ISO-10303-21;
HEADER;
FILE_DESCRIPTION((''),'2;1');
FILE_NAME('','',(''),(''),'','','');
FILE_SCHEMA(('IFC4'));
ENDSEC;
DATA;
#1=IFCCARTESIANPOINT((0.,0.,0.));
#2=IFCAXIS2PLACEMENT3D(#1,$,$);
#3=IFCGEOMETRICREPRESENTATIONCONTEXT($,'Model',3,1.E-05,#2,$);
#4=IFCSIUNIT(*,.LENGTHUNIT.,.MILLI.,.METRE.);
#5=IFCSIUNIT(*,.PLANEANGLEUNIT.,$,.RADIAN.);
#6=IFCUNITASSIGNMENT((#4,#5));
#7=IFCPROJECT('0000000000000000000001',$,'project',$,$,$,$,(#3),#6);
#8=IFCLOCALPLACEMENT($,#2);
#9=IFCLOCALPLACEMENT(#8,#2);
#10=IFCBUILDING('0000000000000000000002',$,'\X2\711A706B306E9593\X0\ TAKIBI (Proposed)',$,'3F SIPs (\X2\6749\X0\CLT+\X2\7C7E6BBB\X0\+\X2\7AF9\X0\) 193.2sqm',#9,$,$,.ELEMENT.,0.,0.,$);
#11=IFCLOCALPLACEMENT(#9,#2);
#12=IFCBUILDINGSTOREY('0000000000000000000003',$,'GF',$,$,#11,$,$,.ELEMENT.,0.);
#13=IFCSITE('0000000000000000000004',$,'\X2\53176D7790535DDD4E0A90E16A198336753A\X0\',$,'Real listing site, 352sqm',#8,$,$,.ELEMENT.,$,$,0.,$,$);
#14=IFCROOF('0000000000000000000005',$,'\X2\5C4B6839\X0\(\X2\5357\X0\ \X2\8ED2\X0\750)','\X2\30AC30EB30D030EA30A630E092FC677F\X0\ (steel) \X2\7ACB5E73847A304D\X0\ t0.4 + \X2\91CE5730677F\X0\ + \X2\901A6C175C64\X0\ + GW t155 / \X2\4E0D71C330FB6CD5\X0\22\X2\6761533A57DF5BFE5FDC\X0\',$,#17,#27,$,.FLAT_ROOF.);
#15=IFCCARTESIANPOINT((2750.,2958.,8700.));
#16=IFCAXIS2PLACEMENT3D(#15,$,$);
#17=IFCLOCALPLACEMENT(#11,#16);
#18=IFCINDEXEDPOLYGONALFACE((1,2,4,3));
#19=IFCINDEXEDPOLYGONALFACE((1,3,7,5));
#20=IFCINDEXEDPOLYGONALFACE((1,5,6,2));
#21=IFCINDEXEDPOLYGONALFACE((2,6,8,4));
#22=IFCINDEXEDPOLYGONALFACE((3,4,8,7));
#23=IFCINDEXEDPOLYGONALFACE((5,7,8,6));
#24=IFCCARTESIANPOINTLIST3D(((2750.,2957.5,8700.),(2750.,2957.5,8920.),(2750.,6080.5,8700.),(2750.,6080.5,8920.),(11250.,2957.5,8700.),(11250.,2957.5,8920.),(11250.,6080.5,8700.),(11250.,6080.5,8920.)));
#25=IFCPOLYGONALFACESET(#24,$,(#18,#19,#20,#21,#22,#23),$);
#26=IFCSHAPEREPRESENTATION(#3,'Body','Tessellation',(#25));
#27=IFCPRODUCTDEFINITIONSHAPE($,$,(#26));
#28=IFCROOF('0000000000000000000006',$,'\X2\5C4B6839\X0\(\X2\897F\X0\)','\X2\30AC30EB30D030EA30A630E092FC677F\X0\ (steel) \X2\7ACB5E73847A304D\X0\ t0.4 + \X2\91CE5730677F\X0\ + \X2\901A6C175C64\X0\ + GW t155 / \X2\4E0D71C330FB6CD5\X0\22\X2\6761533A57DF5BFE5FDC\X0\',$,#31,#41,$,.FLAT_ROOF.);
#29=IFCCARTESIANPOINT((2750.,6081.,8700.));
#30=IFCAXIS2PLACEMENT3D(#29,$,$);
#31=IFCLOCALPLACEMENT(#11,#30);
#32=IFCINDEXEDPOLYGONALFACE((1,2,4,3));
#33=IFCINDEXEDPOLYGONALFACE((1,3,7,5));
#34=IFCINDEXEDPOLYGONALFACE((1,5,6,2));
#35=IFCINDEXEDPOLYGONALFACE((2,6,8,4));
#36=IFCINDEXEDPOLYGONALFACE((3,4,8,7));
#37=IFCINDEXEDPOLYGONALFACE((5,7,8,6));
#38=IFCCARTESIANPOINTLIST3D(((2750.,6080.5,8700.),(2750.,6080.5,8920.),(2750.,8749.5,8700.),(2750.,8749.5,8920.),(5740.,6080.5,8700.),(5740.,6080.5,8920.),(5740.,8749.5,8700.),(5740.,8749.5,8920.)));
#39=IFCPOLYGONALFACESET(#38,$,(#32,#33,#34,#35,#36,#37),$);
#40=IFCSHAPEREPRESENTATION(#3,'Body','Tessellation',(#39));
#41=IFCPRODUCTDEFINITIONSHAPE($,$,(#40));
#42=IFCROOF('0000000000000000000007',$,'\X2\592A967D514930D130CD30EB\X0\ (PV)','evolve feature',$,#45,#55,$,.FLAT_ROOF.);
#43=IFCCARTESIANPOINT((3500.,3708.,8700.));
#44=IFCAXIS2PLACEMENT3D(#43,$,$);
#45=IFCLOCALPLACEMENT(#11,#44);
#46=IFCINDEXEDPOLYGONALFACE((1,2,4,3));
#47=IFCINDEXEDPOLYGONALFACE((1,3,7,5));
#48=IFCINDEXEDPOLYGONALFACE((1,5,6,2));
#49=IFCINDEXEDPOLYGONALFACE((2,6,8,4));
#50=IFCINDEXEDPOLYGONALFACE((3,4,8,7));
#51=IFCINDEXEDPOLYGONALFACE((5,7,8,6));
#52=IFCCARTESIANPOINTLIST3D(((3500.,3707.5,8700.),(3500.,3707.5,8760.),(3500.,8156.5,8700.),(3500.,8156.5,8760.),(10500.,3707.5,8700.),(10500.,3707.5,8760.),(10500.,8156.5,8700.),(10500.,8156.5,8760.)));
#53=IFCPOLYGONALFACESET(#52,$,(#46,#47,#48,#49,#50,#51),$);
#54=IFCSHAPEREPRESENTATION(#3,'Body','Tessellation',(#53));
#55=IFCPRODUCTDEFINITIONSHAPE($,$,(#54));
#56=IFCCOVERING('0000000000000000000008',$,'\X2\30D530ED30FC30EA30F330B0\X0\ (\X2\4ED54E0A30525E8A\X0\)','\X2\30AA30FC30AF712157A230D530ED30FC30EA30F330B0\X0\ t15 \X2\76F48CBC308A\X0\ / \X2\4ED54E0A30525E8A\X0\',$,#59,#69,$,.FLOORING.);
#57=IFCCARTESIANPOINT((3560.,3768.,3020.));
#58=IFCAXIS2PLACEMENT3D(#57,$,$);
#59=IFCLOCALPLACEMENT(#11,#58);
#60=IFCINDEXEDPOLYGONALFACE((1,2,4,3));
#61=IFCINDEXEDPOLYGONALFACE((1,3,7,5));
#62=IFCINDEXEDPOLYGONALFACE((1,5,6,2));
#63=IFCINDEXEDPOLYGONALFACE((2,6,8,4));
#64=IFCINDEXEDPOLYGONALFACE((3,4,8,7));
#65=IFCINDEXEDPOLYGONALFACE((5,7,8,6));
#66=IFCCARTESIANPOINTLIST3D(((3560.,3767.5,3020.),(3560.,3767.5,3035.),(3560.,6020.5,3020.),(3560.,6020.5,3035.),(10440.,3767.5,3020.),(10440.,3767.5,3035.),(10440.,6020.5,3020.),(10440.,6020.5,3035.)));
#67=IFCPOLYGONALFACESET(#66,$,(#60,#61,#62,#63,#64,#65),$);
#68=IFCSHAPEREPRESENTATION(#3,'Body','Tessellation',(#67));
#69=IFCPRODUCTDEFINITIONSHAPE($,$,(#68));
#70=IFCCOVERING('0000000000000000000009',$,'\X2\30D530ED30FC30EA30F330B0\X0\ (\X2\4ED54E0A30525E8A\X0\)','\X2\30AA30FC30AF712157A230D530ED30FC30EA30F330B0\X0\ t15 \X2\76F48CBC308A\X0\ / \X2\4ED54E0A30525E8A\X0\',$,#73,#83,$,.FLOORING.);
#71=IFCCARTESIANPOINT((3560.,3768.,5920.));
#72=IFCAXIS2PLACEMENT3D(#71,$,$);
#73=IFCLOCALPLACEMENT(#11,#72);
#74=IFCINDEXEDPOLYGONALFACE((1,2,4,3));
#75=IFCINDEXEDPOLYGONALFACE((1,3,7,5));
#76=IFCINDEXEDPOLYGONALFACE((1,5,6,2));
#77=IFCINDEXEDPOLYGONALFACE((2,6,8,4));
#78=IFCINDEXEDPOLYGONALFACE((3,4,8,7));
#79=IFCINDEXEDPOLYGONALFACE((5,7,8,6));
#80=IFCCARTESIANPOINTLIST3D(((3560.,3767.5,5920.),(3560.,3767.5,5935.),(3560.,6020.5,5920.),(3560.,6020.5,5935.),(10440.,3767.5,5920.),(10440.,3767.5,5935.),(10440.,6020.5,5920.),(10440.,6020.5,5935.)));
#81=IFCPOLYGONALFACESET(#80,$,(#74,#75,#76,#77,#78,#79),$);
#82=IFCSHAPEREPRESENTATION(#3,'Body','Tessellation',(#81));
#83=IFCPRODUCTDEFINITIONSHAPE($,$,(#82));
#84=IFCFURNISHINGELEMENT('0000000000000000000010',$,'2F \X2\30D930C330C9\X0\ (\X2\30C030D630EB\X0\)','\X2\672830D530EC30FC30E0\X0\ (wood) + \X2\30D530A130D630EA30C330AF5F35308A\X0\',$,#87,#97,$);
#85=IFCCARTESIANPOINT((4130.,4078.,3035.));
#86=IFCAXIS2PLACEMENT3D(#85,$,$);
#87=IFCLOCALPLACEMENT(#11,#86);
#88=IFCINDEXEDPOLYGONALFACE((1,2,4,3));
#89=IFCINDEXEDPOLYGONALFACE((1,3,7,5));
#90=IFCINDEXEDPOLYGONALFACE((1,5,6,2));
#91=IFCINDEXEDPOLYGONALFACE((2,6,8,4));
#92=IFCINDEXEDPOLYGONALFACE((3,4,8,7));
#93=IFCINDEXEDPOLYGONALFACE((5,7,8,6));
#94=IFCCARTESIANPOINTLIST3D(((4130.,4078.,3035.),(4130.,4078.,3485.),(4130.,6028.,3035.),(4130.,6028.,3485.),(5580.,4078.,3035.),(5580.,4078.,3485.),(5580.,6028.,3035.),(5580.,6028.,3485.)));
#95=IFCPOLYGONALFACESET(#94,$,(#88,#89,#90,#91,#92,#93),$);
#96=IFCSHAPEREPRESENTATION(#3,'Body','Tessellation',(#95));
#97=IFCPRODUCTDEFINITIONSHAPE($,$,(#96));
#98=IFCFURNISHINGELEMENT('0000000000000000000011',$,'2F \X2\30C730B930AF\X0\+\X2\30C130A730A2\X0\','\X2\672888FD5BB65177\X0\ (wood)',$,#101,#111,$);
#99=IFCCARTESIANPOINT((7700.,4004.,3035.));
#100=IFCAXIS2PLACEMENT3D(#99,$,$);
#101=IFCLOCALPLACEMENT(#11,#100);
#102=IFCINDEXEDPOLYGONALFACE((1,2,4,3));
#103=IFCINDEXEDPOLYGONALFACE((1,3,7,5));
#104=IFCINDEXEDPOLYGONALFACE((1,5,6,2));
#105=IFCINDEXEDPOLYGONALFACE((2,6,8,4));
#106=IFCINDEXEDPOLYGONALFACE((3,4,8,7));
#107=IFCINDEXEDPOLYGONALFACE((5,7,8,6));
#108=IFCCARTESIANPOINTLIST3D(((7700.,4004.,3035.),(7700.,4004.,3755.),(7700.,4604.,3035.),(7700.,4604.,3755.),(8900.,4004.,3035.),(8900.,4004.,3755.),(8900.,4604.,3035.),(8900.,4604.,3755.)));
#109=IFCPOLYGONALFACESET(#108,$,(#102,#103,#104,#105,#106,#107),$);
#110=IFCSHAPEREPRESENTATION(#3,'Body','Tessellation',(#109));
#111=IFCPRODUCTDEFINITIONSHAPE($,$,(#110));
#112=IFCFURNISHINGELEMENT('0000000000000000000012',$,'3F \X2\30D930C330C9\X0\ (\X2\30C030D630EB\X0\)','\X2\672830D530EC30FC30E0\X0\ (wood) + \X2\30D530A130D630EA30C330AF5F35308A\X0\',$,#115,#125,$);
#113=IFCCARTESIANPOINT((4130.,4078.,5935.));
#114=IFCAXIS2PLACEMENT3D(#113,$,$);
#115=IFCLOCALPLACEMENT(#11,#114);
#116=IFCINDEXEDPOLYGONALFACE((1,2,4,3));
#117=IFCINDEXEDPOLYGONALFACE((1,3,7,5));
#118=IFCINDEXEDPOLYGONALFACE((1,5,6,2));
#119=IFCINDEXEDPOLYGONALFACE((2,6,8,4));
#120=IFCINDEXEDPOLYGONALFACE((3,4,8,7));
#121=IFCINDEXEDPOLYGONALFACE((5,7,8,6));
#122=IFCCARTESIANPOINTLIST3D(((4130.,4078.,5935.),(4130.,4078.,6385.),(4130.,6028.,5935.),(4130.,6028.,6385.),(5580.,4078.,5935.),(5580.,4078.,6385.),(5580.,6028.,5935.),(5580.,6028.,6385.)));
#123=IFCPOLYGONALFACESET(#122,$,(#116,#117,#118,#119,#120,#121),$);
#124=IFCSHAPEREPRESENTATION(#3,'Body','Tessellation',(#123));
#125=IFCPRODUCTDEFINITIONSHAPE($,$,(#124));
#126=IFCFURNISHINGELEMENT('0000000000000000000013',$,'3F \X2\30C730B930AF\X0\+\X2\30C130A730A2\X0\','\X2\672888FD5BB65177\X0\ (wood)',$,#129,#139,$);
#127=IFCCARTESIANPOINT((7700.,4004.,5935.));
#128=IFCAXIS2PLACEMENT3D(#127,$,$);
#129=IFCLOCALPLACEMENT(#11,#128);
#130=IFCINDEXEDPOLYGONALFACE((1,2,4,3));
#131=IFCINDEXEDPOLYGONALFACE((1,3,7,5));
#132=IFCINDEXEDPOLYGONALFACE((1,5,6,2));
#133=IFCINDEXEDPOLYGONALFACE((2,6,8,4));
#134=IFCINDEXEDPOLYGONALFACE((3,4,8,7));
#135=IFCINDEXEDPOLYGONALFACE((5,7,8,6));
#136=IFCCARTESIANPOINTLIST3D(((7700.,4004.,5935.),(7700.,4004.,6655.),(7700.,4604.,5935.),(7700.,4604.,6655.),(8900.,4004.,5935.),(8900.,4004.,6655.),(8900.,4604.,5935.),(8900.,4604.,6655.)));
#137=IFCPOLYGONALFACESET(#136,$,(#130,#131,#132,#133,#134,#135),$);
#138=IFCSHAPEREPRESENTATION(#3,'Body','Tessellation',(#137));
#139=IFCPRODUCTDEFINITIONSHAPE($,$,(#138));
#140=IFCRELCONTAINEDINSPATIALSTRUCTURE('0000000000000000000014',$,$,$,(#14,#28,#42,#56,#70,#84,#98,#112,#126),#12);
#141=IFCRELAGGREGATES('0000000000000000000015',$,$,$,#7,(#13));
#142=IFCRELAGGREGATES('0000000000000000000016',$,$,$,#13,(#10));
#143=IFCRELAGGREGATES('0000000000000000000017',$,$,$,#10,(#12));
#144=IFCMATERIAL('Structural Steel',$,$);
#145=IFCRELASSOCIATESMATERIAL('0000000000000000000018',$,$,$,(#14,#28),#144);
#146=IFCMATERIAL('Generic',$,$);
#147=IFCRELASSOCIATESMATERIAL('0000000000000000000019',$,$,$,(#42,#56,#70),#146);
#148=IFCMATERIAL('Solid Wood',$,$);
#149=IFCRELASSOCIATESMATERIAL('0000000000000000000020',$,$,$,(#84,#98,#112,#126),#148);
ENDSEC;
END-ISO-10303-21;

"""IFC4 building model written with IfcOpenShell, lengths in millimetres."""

from ifc_helpers import new_model, si_unit, frame, frame_2d, origin, place, context, project, spatial, rectangle, extrude, material, element, save


model = new_model("IFC4")

# Units and contexts
model_context = context("Model", 3, precision=1e-05, world=origin())
ifc_project = project(units=[si_unit("LENGTHUNIT", "METRE", prefix="MILLI"), si_unit("PLANEANGLEUNIT", "RADIAN")], contexts=[model_context])

# Site, building, storey
site_placement = place(None, origin())
site = spatial("IfcSite", under=ifc_project, at=site_placement, Name="北海道川上郡標茶町", ObjectType="Real listing site, 352sqm", CompositionType="ELEMENT", RefElevation=0.0)
building_placement = place(site_placement, origin())
building = spatial("IfcBuilding", under=site, at=building_placement, Name="焚火の間 TAKIBI (Proposed)", ObjectType="3F SIPs (杉CLT+籾殻+竹) 193.2sqm", CompositionType="ELEMENT", ElevationOfRefHeight=0.0, ElevationOfTerrain=0.0)
storey_placement = place(building_placement, origin())
storey = spatial("IfcBuildingStorey", under=building, at=storey_placement, Name="GF", CompositionType="ELEMENT", Elevation=0.0)

# Shared definitions
ifc_material_1 = material(Name="Solid Wood")

# Roofs
ifc_material_2 = material(Name="Structural Steel")
roof_1_placement = place(storey_placement, frame((2750.0, 2958.0, 8700.0)))
element("IfcRoof", 1, at=roof_1_placement, inside=storey, material=ifc_material_2, Name="屋根(南 軒750)", Description="ガルバリウム鋼板 (steel) 立平葺き t0.4 + 野地板 + 通気層 + GW t155 / 不燃・法22条区域対応", PredefinedType="FLAT_ROOF", context=model_context, shape_type="SweptSolid", body=[
    extrude(rectangle(XDim=8500.0, YDim=3123.0, at=frame_2d((4250.0, 1561.0))), frame((2750.0, 2958.0, 8700.0)), (0.0, 0.0, 1.0), 220.0),
])
roof_2_placement = place(storey_placement, frame((2750.0, 6081.0, 8700.0)))
element("IfcRoof", 2, at=roof_2_placement, inside=storey, material=ifc_material_2, Name="屋根(西)", Description="ガルバリウム鋼板 (steel) 立平葺き t0.4 + 野地板 + 通気層 + GW t155 / 不燃・法22条区域対応", PredefinedType="FLAT_ROOF", context=model_context, shape_type="SweptSolid", body=[
    extrude(rectangle(XDim=2990.0, YDim=2669.0, at=frame_2d((1495.0, 1334.0))), frame((2750.0, 6081.0, 8700.0)), (0.0, 0.0, 1.0), 220.0),
])
ifc_material_3 = material(Name="Generic")
roof_3_placement = place(storey_placement, frame((3500.0, 3708.0, 8700.0)))
element("IfcRoof", 3, at=roof_3_placement, inside=storey, material=ifc_material_3, Name="太陽光パネル (PV)", Description="evolve feature", PredefinedType="FLAT_ROOF", context=model_context, shape_type="SweptSolid", body=[
    extrude(rectangle(XDim=7000.0, YDim=4449.0, at=frame_2d((3500.0, 2224.0))), frame((3500.0, 3708.0, 8700.0)), (0.0, 0.0, 1.0), 60.0),
])

# Coverings
covering_1_placement = place(storey_placement, frame((3560.0, 3768.0, 3020.0)))
element("IfcCovering", 4, at=covering_1_placement, inside=storey, material=ifc_material_3, Name="フローリング (仕上げ床)", Description="オーク無垢フローリング t15 直貼り / 仕上げ床", PredefinedType="FLOORING", context=model_context, shape_type="SweptSolid", body=[
    extrude(rectangle(XDim=6880.0, YDim=2253.0, at=frame_2d((3440.0, 1126.0))), frame((3560.0, 3768.0, 3020.0)), (0.0, 0.0, 1.0), 15.0),
])
covering_2_placement = place(storey_placement, frame((3560.0, 3768.0, 5920.0)))
element("IfcCovering", 5, at=covering_2_placement, inside=storey, material=ifc_material_3, Name="フローリング (仕上げ床)", Description="オーク無垢フローリング t15 直貼り / 仕上げ床", PredefinedType="FLOORING", context=model_context, shape_type="SweptSolid", body=[
    extrude(rectangle(XDim=6880.0, YDim=2253.0, at=frame_2d((3440.0, 1126.0))), frame((3560.0, 3768.0, 5920.0)), (0.0, 0.0, 1.0), 15.0),
])

# Furnishing elements
furnishing_1_placement = place(storey_placement, frame((4130.0, 4078.0, 3035.0)))
element("IfcFurnishingElement", 6, at=furnishing_1_placement, inside=storey, material=ifc_material_1, Name="2F ベッド (ダブル)", Description="木フレーム (wood) + ファブリック張り", context=model_context, shape_type="SweptSolid", body=[
    extrude(rectangle(XDim=1450.0, YDim=1950.0, at=frame_2d((725.0, 975.0))), frame((4130.0, 4078.0, 3035.0)), (0.0, 0.0, 1.0), 450.0),
])
furnishing_2_placement = place(storey_placement, frame((7700.0, 4004.0, 3035.0)))
element("IfcFurnishingElement", 7, at=furnishing_2_placement, inside=storey, material=ifc_material_1, Name="2F デスク+チェア", Description="木製家具 (wood)", context=model_context, shape_type="SweptSolid", body=[
    extrude(rectangle(XDim=1200.0, YDim=600.0, at=frame_2d((600.0, 300.0))), frame((7700.0, 4004.0, 3035.0)), (0.0, 0.0, 1.0), 720.0),
])
furnishing_3_placement = place(storey_placement, frame((4130.0, 4078.0, 5935.0)))
element("IfcFurnishingElement", 8, at=furnishing_3_placement, inside=storey, material=ifc_material_1, Name="3F ベッド (ダブル)", Description="木フレーム (wood) + ファブリック張り", context=model_context, shape_type="SweptSolid", body=[
    extrude(rectangle(XDim=1450.0, YDim=1950.0, at=frame_2d((725.0, 975.0))), frame((4130.0, 4078.0, 5935.0)), (0.0, 0.0, 1.0), 450.0),
])
furnishing_4_placement = place(storey_placement, frame((7700.0, 4004.0, 5935.0)))
element("IfcFurnishingElement", 9, at=furnishing_4_placement, inside=storey, material=ifc_material_1, Name="3F デスク+チェア", Description="木製家具 (wood)", context=model_context, shape_type="SweptSolid", body=[
    extrude(rectangle(XDim=1200.0, YDim=600.0, at=frame_2d((600.0, 300.0))), frame((7700.0, 4004.0, 5935.0)), (0.0, 0.0, 1.0), 720.0),
])

save(model, "model.ifc")
